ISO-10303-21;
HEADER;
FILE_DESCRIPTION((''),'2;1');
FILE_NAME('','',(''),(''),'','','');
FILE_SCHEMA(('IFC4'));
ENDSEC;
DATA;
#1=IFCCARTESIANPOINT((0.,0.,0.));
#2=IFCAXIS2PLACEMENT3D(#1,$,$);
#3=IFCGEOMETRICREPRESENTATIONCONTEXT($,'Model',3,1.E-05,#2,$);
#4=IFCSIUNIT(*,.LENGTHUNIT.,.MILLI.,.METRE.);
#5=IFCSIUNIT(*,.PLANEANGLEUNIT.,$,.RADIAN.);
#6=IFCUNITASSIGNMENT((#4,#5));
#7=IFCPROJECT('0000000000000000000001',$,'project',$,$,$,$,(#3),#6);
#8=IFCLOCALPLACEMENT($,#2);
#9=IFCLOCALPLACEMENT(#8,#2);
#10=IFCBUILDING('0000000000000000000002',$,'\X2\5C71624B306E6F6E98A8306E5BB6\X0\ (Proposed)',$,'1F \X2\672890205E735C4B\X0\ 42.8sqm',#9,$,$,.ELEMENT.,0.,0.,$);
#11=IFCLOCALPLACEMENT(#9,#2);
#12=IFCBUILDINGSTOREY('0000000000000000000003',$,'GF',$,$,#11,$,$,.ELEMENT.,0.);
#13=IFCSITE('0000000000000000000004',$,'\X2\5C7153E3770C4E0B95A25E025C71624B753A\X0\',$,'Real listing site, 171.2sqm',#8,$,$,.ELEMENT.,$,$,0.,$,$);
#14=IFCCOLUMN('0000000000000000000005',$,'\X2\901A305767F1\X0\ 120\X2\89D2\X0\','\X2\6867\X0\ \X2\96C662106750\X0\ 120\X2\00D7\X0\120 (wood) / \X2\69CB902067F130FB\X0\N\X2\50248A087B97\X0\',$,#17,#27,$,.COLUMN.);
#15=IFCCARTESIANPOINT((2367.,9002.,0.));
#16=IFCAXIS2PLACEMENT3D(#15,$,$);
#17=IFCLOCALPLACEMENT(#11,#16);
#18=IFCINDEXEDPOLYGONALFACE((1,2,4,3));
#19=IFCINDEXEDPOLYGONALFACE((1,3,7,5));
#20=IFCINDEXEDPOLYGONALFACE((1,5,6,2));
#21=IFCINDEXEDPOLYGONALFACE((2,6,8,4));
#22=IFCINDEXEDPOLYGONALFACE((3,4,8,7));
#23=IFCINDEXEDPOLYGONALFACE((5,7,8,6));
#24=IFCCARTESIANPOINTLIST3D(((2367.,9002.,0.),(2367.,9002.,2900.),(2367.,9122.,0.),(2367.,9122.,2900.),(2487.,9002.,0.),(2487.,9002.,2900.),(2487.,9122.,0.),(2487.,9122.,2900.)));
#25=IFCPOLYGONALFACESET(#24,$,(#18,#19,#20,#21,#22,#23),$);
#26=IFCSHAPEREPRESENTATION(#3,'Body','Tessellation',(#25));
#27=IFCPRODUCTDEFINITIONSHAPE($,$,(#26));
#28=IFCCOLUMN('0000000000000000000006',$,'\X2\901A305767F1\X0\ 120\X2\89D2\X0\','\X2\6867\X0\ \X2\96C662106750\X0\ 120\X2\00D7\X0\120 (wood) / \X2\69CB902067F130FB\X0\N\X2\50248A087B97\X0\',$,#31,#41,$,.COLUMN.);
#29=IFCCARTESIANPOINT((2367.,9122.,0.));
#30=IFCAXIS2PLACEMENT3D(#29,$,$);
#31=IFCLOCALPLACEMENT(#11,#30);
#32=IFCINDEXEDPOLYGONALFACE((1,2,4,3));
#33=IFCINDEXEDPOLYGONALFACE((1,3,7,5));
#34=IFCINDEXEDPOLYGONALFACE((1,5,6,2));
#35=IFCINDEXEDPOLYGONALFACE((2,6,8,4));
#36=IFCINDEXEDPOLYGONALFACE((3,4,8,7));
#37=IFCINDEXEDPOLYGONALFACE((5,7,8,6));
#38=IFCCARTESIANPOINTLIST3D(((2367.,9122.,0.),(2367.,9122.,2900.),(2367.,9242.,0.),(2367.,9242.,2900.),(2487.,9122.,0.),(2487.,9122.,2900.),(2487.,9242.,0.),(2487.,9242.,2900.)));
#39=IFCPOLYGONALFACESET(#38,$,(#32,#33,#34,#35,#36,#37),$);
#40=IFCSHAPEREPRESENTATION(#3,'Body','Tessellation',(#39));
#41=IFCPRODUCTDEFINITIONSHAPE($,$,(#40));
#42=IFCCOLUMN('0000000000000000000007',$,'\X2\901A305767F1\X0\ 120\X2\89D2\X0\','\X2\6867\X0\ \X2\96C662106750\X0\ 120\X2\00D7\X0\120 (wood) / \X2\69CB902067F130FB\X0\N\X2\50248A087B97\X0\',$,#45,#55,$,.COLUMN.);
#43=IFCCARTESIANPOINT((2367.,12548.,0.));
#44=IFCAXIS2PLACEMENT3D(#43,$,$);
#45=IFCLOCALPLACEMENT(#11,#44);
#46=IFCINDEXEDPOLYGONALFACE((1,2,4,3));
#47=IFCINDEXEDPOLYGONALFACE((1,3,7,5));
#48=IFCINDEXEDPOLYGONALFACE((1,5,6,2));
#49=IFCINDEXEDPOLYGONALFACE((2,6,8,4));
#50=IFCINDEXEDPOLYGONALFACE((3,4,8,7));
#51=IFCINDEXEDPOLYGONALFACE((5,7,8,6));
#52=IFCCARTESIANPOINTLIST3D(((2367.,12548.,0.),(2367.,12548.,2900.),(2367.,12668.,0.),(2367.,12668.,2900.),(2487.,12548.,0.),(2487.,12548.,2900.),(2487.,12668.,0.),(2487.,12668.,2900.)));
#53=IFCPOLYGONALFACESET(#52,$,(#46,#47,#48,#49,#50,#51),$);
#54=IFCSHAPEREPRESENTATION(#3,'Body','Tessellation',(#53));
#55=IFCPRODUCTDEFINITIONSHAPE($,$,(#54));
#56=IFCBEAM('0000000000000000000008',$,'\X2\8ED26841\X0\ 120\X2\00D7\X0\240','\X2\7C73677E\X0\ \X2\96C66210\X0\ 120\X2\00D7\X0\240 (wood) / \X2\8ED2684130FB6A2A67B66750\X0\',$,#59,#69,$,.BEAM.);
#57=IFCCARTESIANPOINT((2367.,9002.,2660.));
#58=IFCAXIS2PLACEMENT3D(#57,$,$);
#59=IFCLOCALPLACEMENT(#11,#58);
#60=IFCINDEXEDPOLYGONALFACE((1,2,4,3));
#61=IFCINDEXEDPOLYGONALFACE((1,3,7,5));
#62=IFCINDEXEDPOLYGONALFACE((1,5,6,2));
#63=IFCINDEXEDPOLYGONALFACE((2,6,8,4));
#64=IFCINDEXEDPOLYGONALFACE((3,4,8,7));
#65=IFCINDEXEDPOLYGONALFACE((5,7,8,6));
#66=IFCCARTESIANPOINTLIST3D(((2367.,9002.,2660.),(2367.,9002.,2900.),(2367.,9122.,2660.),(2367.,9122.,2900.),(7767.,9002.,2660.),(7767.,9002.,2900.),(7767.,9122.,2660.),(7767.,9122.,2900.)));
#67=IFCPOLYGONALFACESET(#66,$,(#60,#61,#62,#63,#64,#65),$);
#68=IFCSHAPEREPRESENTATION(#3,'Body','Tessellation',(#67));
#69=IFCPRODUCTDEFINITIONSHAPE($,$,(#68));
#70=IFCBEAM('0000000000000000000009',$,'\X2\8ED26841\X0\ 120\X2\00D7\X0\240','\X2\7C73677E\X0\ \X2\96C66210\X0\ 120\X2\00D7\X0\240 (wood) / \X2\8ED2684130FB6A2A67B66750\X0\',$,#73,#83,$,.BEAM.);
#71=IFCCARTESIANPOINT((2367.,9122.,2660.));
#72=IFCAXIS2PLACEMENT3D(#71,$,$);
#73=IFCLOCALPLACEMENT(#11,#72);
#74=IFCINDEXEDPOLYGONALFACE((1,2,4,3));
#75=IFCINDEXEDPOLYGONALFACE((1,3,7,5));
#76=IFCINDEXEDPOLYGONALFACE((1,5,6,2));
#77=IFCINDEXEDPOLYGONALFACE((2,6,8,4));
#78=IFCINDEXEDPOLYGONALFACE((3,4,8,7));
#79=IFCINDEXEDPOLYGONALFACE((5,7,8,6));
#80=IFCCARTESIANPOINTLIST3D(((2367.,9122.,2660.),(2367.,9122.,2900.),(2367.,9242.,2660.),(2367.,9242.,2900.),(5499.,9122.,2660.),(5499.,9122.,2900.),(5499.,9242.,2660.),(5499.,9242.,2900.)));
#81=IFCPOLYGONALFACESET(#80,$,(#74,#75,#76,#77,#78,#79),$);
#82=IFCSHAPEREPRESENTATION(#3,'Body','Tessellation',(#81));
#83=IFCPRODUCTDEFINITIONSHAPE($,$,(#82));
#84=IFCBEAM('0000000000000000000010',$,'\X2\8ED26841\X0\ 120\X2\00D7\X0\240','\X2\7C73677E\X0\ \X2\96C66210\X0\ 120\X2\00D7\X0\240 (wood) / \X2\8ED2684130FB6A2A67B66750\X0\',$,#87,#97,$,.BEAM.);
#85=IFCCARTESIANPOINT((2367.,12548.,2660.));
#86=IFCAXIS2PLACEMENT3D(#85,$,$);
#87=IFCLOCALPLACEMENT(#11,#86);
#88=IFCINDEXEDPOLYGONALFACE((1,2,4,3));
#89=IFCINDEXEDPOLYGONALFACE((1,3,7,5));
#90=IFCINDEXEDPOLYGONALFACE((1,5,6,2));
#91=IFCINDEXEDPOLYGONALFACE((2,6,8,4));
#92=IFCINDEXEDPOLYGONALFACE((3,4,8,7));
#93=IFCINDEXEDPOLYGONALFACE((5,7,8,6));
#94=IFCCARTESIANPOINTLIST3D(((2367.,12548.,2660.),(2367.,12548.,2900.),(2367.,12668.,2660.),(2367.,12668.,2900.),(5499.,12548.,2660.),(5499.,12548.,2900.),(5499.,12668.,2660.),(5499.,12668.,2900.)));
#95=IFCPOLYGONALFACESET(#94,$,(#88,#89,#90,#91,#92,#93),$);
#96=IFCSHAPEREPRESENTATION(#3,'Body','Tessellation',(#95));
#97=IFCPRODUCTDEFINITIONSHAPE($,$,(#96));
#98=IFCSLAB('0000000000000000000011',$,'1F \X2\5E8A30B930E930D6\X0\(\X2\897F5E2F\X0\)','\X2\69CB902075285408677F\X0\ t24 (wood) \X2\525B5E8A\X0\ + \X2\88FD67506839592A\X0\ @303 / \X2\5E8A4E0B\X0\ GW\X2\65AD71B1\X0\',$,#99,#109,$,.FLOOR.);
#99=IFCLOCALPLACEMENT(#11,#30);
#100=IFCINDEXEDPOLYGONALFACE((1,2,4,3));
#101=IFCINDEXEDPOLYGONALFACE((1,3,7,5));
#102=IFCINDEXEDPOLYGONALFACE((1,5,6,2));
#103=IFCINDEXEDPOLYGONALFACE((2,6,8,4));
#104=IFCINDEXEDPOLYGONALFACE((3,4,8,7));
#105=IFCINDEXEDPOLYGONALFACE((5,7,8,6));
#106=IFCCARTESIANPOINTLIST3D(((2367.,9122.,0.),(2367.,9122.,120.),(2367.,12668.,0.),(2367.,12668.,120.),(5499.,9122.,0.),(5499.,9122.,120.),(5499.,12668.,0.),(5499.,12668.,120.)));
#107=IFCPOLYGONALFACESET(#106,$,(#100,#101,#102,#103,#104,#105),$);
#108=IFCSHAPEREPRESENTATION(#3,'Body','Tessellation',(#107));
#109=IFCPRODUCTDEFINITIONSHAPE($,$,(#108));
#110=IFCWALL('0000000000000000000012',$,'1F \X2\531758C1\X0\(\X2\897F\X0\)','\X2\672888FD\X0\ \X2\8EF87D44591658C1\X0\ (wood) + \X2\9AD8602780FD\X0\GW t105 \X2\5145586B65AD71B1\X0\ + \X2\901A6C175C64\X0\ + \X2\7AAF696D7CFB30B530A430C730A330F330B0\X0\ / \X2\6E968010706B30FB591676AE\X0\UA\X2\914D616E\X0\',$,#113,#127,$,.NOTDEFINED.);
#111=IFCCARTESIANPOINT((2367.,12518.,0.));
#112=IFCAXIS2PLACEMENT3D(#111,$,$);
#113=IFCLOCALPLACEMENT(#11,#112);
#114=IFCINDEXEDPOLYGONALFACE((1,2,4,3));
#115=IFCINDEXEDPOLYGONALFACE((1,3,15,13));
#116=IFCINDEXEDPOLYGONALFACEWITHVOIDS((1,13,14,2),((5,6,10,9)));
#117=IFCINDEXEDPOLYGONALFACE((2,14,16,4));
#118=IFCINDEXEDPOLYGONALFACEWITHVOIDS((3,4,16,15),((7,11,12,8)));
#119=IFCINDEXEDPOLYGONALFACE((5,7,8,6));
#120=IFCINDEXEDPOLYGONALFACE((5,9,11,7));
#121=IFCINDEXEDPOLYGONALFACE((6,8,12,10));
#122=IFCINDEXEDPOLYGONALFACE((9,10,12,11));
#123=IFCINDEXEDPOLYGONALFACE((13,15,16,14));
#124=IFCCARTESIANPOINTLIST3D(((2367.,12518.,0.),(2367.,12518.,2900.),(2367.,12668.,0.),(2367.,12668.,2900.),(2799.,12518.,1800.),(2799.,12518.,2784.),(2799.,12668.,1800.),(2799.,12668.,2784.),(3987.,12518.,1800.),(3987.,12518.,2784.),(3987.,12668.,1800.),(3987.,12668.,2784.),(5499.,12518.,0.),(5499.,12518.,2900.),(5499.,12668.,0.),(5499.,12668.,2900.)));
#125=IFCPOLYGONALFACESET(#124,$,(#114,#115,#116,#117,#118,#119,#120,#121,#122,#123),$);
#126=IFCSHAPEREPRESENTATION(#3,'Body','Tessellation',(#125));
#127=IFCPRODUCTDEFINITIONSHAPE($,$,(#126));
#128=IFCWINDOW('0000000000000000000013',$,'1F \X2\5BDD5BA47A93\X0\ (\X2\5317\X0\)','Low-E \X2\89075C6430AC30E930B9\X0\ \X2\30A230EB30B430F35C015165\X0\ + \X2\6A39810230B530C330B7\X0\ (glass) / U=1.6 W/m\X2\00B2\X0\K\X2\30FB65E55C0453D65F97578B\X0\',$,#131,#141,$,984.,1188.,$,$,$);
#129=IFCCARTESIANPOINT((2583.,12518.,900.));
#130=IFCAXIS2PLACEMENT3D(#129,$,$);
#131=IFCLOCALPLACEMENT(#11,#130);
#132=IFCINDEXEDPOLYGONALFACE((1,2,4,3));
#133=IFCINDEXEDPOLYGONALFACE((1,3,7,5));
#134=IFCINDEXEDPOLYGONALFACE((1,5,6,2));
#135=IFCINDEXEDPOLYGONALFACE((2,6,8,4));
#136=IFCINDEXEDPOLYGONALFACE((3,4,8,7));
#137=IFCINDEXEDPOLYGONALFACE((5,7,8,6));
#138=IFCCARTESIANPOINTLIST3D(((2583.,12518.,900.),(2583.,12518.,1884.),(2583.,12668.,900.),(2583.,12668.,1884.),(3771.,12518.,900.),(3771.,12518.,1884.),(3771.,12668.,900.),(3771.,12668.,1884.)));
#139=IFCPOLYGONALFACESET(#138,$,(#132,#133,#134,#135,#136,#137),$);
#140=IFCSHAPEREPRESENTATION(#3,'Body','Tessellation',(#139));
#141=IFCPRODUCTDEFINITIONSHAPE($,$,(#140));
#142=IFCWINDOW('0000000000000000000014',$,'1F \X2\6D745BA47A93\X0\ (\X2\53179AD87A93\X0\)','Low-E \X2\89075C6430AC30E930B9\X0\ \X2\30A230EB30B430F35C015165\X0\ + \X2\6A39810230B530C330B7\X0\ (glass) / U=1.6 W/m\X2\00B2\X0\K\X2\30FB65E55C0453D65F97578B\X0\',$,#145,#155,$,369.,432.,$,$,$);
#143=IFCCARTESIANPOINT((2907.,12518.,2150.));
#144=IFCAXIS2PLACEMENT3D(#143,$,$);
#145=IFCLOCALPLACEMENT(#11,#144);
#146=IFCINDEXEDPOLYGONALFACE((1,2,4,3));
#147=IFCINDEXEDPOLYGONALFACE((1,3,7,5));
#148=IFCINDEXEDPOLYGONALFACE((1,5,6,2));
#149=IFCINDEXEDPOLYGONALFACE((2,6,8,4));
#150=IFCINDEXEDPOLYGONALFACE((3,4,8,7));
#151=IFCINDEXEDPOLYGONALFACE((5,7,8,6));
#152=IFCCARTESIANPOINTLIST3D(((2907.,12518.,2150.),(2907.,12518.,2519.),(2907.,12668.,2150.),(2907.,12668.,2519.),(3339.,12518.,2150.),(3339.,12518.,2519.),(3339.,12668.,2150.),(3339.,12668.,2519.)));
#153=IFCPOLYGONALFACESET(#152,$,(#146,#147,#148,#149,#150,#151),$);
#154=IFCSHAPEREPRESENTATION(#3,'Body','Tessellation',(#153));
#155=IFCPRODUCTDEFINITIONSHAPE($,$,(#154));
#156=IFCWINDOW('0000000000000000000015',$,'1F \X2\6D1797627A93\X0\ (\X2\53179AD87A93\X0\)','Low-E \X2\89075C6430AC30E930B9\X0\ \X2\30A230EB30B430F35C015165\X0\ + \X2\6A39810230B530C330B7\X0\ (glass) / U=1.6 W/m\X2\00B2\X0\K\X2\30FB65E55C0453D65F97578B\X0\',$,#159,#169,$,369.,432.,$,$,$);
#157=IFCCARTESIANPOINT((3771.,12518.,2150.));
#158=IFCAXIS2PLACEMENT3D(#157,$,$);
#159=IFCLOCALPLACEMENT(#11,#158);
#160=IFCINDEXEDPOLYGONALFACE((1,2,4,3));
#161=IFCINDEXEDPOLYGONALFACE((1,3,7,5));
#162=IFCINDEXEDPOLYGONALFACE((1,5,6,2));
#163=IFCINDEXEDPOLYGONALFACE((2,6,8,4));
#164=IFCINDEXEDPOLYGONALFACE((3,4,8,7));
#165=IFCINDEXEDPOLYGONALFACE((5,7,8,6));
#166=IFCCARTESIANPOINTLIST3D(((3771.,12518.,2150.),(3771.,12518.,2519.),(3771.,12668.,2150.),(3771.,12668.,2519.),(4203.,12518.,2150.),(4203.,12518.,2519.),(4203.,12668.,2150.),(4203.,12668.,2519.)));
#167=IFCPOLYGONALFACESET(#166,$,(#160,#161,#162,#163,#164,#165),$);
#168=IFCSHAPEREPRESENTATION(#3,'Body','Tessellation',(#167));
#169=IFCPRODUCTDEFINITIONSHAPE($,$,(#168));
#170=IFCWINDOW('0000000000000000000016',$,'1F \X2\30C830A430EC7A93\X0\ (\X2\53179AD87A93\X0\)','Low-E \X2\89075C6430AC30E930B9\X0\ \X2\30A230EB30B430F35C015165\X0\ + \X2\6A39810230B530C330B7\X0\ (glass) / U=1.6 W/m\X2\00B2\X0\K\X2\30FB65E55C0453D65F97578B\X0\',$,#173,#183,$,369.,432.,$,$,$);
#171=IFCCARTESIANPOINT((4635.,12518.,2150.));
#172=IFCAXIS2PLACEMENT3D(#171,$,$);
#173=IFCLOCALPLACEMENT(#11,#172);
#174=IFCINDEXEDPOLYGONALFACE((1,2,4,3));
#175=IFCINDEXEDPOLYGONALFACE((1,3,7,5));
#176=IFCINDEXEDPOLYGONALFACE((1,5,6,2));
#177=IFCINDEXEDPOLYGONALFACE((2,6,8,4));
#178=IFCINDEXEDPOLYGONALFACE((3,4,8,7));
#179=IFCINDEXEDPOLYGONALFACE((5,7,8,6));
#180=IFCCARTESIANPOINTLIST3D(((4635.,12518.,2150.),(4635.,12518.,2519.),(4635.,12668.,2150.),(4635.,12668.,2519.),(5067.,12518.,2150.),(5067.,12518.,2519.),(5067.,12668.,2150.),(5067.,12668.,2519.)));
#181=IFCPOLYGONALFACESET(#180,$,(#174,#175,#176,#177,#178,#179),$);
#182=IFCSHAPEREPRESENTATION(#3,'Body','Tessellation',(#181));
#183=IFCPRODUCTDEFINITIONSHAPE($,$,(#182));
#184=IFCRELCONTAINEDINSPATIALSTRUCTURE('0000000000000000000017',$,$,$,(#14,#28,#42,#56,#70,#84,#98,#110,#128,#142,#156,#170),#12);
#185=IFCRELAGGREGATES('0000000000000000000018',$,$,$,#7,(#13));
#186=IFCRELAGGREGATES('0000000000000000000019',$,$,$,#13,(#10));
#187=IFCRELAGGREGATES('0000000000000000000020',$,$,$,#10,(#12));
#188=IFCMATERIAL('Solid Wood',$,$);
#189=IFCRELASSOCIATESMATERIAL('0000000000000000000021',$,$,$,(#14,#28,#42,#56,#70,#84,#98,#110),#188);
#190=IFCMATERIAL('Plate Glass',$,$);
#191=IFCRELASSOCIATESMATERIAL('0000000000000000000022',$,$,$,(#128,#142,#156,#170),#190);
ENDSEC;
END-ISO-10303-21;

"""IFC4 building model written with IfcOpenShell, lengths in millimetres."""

from ifc_helpers import new_model, si_unit, frame, frame_2d, origin, place, context, project, spatial, rectangle, extrude, material, element, fill, save


model = new_model("IFC4")

# Units and contexts
model_context = context("Model", 3, precision=1e-05, world=origin())
ifc_project = project(units=[si_unit("LENGTHUNIT", "METRE", prefix="MILLI"), si_unit("PLANEANGLEUNIT", "RADIAN")], contexts=[model_context])

# Site, building, storey
site_placement = place(None, origin())
site = spatial("IfcSite", under=ifc_project, at=site_placement, Name="山口県下関市山手町", ObjectType="Real listing site, 171.2sqm", CompositionType="ELEMENT", RefElevation=0.0)
building_placement = place(site_placement, origin())
building = spatial("IfcBuilding", under=site, at=building_placement, Name="山手の潮風の家 (Proposed)", ObjectType="1F 木造平屋 42.8sqm", CompositionType="ELEMENT", ElevationOfRefHeight=0.0, ElevationOfTerrain=0.0)
storey_placement = place(building_placement, origin())
storey = spatial("IfcBuildingStorey", under=building, at=storey_placement, Name="GF", CompositionType="ELEMENT", Elevation=0.0)

# Columns
ifc_material_1 = material(Name="Solid Wood")
column_1_placement = place(storey_placement, frame((2367.0, 9002.0, 0.0)))
element("IfcColumn", 1, at=column_1_placement, inside=storey, material=ifc_material_1, Name="通し柱 120角", Description="桧 集成材 120×120 (wood) / 構造柱・N値計算", PredefinedType="COLUMN", context=model_context, shape_type="SweptSolid", body=[
    extrude(rectangle(XDim=120.0, YDim=120.0, at=frame_2d((60.0, 60.0))), frame((2367.0, 9002.0, 0.0)), (0.0, 0.0, 1.0), 2900.0),
])
column_2_placement = place(storey_placement, frame((2367.0, 9122.0, 0.0)))
element("IfcColumn", 2, at=column_2_placement, inside=storey, material=ifc_material_1, Name="通し柱 120角", Description="桧 集成材 120×120 (wood) / 構造柱・N値計算", PredefinedType="COLUMN", context=model_context, shape_type="SweptSolid", body=[
    extrude(rectangle(XDim=120.0, YDim=120.0, at=frame_2d((60.0, 60.0))), frame((2367.0, 9122.0, 0.0)), (0.0, 0.0, 1.0), 2900.0),
])
column_3_placement = place(storey_placement, frame((2367.0, 12548.0, 0.0)))
element("IfcColumn", 3, at=column_3_placement, inside=storey, material=ifc_material_1, Name="通し柱 120角", Description="桧 集成材 120×120 (wood) / 構造柱・N値計算", PredefinedType="COLUMN", context=model_context, shape_type="SweptSolid", body=[
    extrude(rectangle(XDim=120.0, YDim=120.0, at=frame_2d((60.0, 60.0))), frame((2367.0, 12548.0, 0.0)), (0.0, 0.0, 1.0), 2900.0),
])

# Beams
beam_1_placement = place(storey_placement, frame((2367.0, 9002.0, 2660.0)))
element("IfcBeam", 4, at=beam_1_placement, inside=storey, material=ifc_material_1, Name="軒桁 120×240", Description="米松 集成 120×240 (wood) / 軒桁・横架材", PredefinedType="BEAM", context=model_context, shape_type="SweptSolid", body=[
    extrude(rectangle(XDim=5400.0, YDim=120.0, at=frame_2d((2700.0, 60.0))), frame((2367.0, 9002.0, 2660.0)), (0.0, 0.0, 1.0), 240.0),
])
beam_2_placement = place(storey_placement, frame((2367.0, 9122.0, 2660.0)))
element("IfcBeam", 5, at=beam_2_placement, inside=storey, material=ifc_material_1, Name="軒桁 120×240", Description="米松 集成 120×240 (wood) / 軒桁・横架材", PredefinedType="BEAM", context=model_context, shape_type="SweptSolid", body=[
    extrude(rectangle(XDim=3132.0, YDim=120.0, at=frame_2d((1566.0, 60.0))), frame((2367.0, 9122.0, 2660.0)), (0.0, 0.0, 1.0), 240.0),
])
beam_3_placement = place(storey_placement, frame((2367.0, 12548.0, 2660.0)))
element("IfcBeam", 6, at=beam_3_placement, inside=storey, material=ifc_material_1, Name="軒桁 120×240", Description="米松 集成 120×240 (wood) / 軒桁・横架材", PredefinedType="BEAM", context=model_context, shape_type="SweptSolid", body=[
    extrude(rectangle(XDim=3132.0, YDim=120.0, at=frame_2d((1566.0, 60.0))), frame((2367.0, 12548.0, 2660.0)), (0.0, 0.0, 1.0), 240.0),
])

# Slab
slab_placement = place(storey_placement, frame((2367.0, 9122.0, 0.0)))
element("IfcSlab", 7, at=slab_placement, inside=storey, material=ifc_material_1, Name="1F 床スラブ(西帯)", Description="構造用合板 t24 (wood) 剛床 + 製材根太 @303 / 床下 GW断熱", PredefinedType="FLOOR", context=model_context, shape_type="SweptSolid", body=[
    extrude(rectangle(XDim=3132.0, YDim=3546.0, at=frame_2d((1566.0, 1773.0))), frame((2367.0, 9122.0, 0.0)), (0.0, 0.0, 1.0), 120.0),
])

# Wall, openings, windows
wall_1_placement = place(storey_placement, frame((2367.0, 12518.0, 0.0)))
wall_1 = element("IfcWall", 8, at=wall_1_placement, inside=storey, material=ifc_material_1, Name="1F 北壁(西)", Description="木製 軸組外壁 (wood) + 高性能GW t105 充填断熱 + 通気層 + 窯業系サイディング / 準耐火・外皮UA配慮", PredefinedType="NOTDEFINED", context=model_context, shape_type="SweptSolid", body=[
    extrude(rectangle(XDim=3132.0, YDim=150.0, at=frame_2d((1566.0, 75.0))), frame((2367.0, 12518.0, 0.0)), (0.0, 0.0, 1.0), 2900.0),
])
opening_1_placement = place(storey_placement, frame((2583.0, 12518.0, 900.0)))
opening_1 = element("IfcOpeningElement", 9, at=opening_1_placement, cuts=wall_1, PredefinedType="NOTDEFINED", context=model_context, shape_type="SweptSolid", body=[
    extrude(rectangle(XDim=1188.0, YDim=150.0, at=frame_2d((594.0, 75.0))), frame((2583.0, 12518.0, 900.0)), (0.0, 0.0, 1.0), 984.0),
])
opening_2_placement = place(storey_placement, frame((2907.0, 12518.0, 2150.0)))
opening_2 = element("IfcOpeningElement", 10, at=opening_2_placement, cuts=wall_1, PredefinedType="NOTDEFINED", context=model_context, shape_type="SweptSolid", body=[
    extrude(rectangle(XDim=432.0, YDim=150.0, at=frame_2d((216.0, 75.0))), frame((2907.0, 12518.0, 2150.0)), (0.0, 0.0, 1.0), 369.0),
])
opening_3_placement = place(storey_placement, frame((3771.0, 12518.0, 2150.0)))
opening_3 = element("IfcOpeningElement", 11, at=opening_3_placement, cuts=wall_1, PredefinedType="NOTDEFINED", context=model_context, shape_type="SweptSolid", body=[
    extrude(rectangle(XDim=432.0, YDim=150.0, at=frame_2d((216.0, 75.0))), frame((3771.0, 12518.0, 2150.0)), (0.0, 0.0, 1.0), 369.0),
])
opening_4_placement = place(storey_placement, frame((4635.0, 12518.0, 2150.0)))
opening_4 = element("IfcOpeningElement", 12, at=opening_4_placement, cuts=wall_1, PredefinedType="NOTDEFINED", context=model_context, shape_type="SweptSolid", body=[
    extrude(rectangle(XDim=432.0, YDim=150.0, at=frame_2d((216.0, 75.0))), frame((4635.0, 12518.0, 2150.0)), (0.0, 0.0, 1.0), 369.0),
])
ifc_material_2 = material(Name="Plate Glass")
window_1_placement = place(storey_placement, frame((2583.0, 12518.0, 900.0)))
window_1 = element("IfcWindow", 13, at=window_1_placement, inside=storey, material=ifc_material_2, Name="1F 寝室窓 (北)", Description="Low-E 複層ガラス アルゴン封入 + 樹脂サッシ (glass) / U=1.6 W/m²K・日射取得型", OverallHeight=984.0, OverallWidth=1188.0, context=model_context, shape_type="SweptSolid", body=[
    extrude(rectangle(XDim=1188.0, YDim=150.0, at=frame_2d((594.0, 75.0))), frame((2583.0, 12518.0, 900.0)), (0.0, 0.0, 1.0), 984.0),
])
fill(opening_1, window_1)
window_2_placement = place(storey_placement, frame((2907.0, 12518.0, 2150.0)))
window_2 = element("IfcWindow", 14, at=window_2_placement, inside=storey, material=ifc_material_2, Name="1F 浴室窓 (北高窓)", Description="Low-E 複層ガラス アルゴン封入 + 樹脂サッシ (glass) / U=1.6 W/m²K・日射取得型", OverallHeight=369.0, OverallWidth=432.0, context=model_context, shape_type="SweptSolid", body=[
    extrude(rectangle(XDim=432.0, YDim=150.0, at=frame_2d((216.0, 75.0))), frame((2907.0, 12518.0, 2150.0)), (0.0, 0.0, 1.0), 369.0),
])
fill(opening_2, window_2)
window_3_placement = place(storey_placement, frame((3771.0, 12518.0, 2150.0)))
window_3 = element("IfcWindow", 15, at=window_3_placement, inside=storey, material=ifc_material_2, Name="1F 洗面窓 (北高窓)", Description="Low-E 複層ガラス アルゴン封入 + 樹脂サッシ (glass) / U=1.6 W/m²K・日射取得型", OverallHeight=369.0, OverallWidth=432.0, context=model_context, shape_type="SweptSolid", body=[
    extrude(rectangle(XDim=432.0, YDim=150.0, at=frame_2d((216.0, 75.0))), frame((3771.0, 12518.0, 2150.0)), (0.0, 0.0, 1.0), 369.0),
])
fill(opening_3, window_3)
window_4_placement = place(storey_placement, frame((4635.0, 12518.0, 2150.0)))
window_4 = element("IfcWindow", 16, at=window_4_placement, inside=storey, material=ifc_material_2, Name="1F トイレ窓 (北高窓)", Description="Low-E 複層ガラス アルゴン封入 + 樹脂サッシ (glass) / U=1.6 W/m²K・日射取得型", OverallHeight=369.0, OverallWidth=432.0, context=model_context, shape_type="SweptSolid", body=[
    extrude(rectangle(XDim=432.0, YDim=150.0, at=frame_2d((216.0, 75.0))), frame((4635.0, 12518.0, 2150.0)), (0.0, 0.0, 1.0), 369.0),
])
fill(opening_4, window_4)

save(model, "model.ifc")
